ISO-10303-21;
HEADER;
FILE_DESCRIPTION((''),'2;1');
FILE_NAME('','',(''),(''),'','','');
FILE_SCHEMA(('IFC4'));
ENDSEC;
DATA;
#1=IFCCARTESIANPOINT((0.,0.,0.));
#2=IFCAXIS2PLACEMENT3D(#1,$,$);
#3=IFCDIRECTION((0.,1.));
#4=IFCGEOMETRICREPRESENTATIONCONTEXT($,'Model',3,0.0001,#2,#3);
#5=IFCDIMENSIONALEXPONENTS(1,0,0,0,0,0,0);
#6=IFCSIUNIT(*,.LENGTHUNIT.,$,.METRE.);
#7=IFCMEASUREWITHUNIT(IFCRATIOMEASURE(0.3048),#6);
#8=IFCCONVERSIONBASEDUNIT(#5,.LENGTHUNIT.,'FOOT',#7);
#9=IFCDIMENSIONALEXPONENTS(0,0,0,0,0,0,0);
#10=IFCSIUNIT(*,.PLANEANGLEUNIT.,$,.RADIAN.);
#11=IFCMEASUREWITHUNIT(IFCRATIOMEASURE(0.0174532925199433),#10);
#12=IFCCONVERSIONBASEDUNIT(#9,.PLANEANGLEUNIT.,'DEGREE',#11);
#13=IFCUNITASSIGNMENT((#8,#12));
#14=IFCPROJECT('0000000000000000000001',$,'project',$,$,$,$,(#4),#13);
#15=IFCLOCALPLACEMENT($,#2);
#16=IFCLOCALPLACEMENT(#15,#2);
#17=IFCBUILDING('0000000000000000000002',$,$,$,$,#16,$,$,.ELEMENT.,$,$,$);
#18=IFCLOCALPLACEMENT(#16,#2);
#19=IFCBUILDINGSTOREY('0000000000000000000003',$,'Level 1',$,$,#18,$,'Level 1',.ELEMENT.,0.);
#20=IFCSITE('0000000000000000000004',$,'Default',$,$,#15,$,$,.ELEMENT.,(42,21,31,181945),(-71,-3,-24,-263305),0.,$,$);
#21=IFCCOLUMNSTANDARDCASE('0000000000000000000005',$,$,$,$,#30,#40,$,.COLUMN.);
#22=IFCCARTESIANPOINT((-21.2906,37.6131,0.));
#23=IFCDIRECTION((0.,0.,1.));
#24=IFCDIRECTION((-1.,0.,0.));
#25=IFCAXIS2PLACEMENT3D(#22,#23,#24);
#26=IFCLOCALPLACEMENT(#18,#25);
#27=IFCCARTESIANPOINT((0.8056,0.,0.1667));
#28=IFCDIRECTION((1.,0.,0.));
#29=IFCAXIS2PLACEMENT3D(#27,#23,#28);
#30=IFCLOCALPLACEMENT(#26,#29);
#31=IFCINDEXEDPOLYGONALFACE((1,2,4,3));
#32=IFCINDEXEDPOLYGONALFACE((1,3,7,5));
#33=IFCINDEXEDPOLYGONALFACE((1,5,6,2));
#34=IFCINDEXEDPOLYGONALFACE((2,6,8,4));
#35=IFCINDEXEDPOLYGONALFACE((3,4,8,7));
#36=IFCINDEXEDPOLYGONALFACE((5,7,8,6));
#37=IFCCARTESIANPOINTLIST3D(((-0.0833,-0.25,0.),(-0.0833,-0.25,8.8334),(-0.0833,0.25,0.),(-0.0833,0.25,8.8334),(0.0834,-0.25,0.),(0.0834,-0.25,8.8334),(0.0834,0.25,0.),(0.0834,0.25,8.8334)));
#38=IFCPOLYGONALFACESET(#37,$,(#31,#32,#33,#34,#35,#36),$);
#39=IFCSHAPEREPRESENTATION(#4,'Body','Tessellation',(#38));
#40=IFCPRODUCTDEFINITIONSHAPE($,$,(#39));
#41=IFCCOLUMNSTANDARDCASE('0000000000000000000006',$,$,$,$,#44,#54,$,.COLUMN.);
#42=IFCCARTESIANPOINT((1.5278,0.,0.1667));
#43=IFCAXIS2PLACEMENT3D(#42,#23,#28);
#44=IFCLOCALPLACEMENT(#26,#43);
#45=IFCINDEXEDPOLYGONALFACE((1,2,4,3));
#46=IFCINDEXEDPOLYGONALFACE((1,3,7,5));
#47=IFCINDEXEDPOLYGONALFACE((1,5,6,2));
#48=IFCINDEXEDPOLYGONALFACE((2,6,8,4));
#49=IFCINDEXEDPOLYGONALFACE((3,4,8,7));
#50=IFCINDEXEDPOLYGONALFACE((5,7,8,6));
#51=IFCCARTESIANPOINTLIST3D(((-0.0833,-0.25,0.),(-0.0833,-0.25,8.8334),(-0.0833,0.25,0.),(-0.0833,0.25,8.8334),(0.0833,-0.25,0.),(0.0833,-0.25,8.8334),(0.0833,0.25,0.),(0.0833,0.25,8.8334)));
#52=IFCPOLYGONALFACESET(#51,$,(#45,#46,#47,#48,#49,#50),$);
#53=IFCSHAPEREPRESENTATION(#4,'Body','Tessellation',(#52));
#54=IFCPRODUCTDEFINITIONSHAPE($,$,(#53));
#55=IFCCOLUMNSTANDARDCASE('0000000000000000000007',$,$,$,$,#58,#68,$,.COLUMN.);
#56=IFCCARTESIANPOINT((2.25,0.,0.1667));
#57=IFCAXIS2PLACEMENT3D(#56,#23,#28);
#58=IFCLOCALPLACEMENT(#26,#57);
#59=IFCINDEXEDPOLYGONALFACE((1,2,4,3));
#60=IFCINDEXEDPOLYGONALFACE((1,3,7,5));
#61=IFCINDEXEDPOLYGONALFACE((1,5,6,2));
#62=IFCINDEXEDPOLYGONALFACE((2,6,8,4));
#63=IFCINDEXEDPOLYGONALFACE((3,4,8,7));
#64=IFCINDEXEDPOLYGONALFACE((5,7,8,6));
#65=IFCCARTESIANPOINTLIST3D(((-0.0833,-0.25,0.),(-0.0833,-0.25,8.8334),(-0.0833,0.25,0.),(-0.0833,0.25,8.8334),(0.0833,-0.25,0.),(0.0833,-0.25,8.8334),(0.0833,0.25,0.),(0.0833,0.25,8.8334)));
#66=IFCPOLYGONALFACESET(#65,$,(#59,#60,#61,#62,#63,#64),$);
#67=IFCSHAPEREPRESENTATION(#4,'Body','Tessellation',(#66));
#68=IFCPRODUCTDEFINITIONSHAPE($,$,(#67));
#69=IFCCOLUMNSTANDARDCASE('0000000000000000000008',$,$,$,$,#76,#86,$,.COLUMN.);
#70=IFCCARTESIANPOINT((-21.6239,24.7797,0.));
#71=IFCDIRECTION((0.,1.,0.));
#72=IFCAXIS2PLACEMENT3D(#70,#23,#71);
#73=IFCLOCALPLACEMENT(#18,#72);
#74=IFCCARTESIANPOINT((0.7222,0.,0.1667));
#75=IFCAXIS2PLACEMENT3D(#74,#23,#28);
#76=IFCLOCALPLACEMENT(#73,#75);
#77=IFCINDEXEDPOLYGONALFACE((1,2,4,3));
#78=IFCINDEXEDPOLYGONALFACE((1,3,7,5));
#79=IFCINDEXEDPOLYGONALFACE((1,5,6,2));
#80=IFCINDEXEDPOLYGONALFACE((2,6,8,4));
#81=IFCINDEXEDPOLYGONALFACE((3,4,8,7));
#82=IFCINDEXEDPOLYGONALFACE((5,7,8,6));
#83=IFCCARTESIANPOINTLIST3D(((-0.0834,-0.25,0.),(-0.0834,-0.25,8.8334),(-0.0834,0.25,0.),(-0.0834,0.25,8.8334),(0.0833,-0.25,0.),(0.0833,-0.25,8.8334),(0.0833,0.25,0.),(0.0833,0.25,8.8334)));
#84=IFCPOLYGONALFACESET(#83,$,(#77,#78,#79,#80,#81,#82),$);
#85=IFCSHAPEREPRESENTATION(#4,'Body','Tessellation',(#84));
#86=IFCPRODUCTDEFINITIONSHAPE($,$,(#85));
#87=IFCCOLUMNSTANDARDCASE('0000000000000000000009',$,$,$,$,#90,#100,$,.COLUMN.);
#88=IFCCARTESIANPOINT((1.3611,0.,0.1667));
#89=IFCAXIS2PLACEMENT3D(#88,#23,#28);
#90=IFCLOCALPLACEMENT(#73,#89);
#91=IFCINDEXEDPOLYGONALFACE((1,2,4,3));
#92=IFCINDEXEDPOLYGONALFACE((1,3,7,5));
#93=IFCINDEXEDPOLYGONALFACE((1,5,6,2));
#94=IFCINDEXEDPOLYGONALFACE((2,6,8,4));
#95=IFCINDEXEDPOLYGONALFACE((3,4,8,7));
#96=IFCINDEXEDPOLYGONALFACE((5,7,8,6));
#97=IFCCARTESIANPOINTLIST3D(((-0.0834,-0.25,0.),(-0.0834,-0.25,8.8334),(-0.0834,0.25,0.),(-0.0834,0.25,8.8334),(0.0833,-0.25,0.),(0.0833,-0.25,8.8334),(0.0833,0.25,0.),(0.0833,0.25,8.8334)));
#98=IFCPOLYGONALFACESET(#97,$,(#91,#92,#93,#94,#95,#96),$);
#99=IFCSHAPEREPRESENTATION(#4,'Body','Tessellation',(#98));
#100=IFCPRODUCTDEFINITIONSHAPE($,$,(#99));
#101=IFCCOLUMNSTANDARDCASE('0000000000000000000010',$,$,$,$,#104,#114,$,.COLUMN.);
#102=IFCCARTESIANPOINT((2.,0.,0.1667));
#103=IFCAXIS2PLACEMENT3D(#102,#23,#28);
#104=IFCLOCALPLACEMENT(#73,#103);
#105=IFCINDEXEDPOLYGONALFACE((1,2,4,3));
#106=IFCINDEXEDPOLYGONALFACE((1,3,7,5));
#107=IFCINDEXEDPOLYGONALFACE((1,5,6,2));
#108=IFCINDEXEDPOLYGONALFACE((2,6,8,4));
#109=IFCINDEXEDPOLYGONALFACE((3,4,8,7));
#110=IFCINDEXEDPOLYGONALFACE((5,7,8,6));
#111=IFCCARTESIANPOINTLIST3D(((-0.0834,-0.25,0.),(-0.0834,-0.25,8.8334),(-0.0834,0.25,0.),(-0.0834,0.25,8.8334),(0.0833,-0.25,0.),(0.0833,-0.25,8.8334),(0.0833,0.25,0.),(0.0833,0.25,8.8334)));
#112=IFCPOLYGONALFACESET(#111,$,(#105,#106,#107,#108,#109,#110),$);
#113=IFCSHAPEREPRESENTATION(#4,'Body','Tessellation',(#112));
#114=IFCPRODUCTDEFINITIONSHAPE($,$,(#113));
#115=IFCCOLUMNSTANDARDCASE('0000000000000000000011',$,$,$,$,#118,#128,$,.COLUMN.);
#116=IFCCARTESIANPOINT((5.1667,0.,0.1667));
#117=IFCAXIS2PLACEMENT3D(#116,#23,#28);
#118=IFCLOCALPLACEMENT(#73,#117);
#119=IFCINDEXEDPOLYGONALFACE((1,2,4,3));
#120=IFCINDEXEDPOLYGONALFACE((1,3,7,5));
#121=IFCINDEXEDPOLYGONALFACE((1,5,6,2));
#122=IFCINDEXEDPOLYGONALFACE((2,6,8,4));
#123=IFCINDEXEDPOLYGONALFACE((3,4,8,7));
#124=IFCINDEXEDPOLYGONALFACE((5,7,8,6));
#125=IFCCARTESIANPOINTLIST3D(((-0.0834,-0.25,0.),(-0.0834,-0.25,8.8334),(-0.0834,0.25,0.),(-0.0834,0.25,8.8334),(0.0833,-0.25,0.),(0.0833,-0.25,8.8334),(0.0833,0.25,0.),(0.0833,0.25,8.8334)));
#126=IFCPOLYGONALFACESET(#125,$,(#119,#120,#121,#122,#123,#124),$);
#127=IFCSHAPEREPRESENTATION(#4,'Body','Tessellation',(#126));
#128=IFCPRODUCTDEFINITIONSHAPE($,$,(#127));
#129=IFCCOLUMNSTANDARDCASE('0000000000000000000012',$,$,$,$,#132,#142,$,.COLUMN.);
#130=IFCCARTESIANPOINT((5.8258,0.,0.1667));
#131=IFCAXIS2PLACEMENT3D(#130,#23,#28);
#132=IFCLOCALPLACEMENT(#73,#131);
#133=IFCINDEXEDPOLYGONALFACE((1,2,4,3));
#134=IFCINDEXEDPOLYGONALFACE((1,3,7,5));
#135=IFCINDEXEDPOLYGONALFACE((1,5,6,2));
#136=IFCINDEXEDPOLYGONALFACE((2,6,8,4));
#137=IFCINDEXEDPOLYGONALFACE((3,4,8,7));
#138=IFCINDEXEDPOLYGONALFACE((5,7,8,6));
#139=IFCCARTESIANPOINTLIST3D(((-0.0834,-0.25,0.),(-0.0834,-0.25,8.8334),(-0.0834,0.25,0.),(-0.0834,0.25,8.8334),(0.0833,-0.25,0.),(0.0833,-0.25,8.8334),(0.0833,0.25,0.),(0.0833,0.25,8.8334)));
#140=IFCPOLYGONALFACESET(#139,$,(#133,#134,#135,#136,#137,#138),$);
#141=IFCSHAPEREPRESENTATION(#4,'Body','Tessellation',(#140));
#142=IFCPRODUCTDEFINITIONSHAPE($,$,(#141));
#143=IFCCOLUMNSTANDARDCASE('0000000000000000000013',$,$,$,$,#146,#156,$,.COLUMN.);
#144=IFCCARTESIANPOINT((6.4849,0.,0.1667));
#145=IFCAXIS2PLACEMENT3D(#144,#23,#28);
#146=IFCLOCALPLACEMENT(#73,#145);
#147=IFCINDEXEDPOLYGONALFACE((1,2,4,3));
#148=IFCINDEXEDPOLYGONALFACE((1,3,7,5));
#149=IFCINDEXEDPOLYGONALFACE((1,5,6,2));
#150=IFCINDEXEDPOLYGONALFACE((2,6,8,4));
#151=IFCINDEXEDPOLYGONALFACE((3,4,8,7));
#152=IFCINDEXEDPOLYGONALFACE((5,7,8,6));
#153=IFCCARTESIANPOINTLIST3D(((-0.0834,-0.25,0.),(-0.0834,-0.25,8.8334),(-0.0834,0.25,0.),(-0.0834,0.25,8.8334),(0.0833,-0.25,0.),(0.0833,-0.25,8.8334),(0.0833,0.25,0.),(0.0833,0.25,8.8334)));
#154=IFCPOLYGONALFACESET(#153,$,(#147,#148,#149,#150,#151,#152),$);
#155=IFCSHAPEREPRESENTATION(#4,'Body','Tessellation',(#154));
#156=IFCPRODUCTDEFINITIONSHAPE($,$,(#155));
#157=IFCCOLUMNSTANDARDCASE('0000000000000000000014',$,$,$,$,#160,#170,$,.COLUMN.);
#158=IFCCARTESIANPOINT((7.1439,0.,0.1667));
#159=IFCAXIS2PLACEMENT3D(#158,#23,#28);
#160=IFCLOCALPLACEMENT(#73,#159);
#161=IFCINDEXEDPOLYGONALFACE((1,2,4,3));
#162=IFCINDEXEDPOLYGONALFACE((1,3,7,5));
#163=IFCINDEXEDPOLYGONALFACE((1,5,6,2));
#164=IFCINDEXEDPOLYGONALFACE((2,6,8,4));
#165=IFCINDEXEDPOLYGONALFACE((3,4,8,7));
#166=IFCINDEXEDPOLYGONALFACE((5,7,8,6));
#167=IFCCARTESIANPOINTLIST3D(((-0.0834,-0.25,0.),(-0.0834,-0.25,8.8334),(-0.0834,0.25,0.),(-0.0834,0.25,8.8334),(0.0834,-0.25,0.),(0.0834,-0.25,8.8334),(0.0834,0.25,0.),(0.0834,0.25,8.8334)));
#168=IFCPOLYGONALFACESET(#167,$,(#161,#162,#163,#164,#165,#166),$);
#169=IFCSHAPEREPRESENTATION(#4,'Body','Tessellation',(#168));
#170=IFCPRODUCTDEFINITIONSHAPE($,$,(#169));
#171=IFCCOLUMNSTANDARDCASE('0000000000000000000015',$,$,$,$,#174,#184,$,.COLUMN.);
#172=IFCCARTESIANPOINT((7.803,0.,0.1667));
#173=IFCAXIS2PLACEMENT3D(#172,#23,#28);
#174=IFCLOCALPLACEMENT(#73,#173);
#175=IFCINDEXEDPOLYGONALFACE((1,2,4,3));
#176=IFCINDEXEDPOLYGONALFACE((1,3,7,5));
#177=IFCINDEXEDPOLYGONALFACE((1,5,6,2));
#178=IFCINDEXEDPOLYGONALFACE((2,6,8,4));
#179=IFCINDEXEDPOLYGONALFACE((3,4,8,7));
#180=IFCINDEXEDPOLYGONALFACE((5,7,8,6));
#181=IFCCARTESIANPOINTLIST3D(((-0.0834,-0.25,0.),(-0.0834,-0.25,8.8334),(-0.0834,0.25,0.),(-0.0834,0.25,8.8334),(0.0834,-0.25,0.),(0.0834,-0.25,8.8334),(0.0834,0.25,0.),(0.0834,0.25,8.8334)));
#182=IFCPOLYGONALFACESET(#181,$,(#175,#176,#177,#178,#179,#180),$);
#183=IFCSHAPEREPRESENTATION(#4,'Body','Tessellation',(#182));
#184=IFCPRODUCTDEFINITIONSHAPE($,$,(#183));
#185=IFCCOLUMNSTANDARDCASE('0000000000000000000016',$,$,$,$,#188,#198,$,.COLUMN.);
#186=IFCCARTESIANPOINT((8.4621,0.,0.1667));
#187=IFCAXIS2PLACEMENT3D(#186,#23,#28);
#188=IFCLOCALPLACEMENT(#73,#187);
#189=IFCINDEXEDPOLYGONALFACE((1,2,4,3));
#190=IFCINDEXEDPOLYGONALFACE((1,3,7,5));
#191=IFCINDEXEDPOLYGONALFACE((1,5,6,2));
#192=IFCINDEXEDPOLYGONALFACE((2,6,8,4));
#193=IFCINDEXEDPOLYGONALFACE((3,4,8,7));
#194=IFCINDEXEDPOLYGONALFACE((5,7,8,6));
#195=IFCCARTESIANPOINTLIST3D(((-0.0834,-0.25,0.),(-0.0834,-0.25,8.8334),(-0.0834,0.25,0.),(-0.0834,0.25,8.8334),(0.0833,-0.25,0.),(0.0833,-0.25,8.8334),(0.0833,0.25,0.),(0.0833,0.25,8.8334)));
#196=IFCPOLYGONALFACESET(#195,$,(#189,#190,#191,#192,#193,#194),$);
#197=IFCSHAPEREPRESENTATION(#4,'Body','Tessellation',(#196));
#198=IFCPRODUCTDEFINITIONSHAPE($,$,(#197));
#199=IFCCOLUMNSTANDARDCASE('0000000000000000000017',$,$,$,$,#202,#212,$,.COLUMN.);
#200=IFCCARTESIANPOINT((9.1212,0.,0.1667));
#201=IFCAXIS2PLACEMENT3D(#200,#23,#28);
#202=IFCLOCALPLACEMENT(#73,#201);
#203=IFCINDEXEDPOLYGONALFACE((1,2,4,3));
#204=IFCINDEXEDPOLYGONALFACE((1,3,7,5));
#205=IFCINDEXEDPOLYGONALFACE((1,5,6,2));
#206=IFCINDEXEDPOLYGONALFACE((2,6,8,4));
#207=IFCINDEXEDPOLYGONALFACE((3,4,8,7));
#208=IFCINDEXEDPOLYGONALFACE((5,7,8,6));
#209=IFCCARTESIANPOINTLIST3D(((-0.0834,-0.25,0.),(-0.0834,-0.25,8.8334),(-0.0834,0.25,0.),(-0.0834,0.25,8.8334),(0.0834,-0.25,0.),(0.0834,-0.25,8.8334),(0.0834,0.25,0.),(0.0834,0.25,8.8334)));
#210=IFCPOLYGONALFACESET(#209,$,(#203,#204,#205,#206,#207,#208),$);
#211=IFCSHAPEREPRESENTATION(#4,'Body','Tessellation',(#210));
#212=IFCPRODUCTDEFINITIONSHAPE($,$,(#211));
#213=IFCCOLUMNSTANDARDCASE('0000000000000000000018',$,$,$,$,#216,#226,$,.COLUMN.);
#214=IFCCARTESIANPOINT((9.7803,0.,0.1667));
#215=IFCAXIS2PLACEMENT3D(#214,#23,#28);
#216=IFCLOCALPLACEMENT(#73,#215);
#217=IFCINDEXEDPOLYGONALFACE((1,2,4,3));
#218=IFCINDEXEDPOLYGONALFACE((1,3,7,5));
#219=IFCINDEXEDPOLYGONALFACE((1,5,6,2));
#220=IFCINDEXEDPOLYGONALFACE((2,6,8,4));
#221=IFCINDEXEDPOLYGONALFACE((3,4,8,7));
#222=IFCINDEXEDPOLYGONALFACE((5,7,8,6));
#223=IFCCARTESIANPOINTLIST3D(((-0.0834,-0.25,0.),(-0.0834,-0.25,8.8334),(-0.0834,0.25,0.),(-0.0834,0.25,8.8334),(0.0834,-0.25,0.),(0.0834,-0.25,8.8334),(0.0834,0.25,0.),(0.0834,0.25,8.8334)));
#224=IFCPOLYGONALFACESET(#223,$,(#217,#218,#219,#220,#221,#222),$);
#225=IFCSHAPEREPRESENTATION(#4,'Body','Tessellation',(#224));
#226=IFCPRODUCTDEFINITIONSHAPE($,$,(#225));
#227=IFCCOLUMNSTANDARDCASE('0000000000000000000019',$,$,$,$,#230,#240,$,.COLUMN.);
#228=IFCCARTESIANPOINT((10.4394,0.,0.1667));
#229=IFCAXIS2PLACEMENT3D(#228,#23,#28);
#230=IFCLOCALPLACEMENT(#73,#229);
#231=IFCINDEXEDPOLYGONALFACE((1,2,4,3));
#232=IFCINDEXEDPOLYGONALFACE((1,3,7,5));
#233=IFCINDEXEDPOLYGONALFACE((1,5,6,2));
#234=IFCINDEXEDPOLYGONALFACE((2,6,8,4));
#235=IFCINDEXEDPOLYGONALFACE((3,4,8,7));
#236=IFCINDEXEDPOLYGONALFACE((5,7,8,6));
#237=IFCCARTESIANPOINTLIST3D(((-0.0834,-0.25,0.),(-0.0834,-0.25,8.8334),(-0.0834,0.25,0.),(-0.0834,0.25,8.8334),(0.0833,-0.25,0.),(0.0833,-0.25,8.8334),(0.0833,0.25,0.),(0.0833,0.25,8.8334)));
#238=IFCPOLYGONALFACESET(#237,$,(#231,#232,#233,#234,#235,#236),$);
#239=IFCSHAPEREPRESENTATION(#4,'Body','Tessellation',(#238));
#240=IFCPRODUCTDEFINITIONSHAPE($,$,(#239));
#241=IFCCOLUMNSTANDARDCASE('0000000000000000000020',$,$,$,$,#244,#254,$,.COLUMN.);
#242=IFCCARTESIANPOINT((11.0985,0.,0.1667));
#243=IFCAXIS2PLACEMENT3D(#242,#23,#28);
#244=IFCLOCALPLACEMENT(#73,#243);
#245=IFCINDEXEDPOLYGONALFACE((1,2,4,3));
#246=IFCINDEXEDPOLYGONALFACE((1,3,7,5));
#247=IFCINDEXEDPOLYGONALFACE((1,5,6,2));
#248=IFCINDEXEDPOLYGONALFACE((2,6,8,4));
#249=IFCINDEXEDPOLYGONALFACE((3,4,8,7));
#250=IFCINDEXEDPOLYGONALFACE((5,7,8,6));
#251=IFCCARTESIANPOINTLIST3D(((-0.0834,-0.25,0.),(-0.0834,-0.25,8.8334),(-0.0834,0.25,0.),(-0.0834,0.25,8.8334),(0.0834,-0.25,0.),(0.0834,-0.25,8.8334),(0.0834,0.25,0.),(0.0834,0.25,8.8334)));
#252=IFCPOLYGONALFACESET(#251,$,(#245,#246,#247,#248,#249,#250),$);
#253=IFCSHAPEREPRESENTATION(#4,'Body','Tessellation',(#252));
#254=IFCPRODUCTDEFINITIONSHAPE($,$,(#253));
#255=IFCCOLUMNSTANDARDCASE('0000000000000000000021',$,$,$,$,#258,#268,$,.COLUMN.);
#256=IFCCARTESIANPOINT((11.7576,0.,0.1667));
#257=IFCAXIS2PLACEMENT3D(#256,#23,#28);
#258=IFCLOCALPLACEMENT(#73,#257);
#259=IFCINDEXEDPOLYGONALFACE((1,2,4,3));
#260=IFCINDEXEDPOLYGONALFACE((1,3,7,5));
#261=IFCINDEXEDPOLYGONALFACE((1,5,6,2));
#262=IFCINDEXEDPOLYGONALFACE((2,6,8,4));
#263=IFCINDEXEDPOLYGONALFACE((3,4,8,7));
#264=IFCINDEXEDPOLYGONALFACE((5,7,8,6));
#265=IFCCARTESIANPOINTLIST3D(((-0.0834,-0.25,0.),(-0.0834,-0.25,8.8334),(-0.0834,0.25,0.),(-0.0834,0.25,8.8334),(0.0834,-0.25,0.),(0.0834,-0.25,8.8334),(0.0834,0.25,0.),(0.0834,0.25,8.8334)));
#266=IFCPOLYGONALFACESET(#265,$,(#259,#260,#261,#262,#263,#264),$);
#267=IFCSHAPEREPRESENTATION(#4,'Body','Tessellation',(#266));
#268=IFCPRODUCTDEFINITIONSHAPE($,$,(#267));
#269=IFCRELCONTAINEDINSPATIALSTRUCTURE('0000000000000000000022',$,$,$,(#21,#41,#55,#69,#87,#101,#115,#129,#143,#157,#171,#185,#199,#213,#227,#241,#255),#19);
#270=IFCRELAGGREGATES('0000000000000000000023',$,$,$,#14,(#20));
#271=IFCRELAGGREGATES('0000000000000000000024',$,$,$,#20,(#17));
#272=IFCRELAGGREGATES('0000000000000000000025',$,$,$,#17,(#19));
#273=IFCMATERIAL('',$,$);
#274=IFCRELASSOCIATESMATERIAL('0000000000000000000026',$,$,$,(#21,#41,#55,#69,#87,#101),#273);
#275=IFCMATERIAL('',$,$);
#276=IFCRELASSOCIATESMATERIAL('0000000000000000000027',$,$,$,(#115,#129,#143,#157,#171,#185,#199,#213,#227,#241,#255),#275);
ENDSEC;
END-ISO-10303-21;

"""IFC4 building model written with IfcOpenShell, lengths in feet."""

from ifc_helpers import new_model, entity, si_unit, converted_unit, direction, frame, origin, place, context, project, spatial, rectangle, extrude, material, element, save


model = new_model("IFC4")

# Units and contexts
model_context = context("Model", 3, precision=0.0001, world=origin(), true_north=direction((0.0, 1.0)))
ifc_project = project(units=[converted_unit("LENGTHUNIT", "FOOT", entity("IfcRatioMeasure", 0.3048), si_unit("LENGTHUNIT", "METRE"), dimensions=[1, 0, 0, 0, 0, 0, 0]), converted_unit("PLANEANGLEUNIT", "DEGREE", entity("IfcRatioMeasure", 0.0174532925199433), si_unit("PLANEANGLEUNIT", "RADIAN"), dimensions=[0, 0, 0, 0, 0, 0, 0])], contexts=[model_context])

# Site, building, storey
site_placement = place(None, origin())
site = spatial("IfcSite", under=ifc_project, at=site_placement, Name="Default", CompositionType="ELEMENT", RefLatitude=(42, 21, 31, 181945), RefLongitude=(-71, -3, -24, -263305), RefElevation=0.0)
building_placement = place(site_placement, origin())
building = spatial("IfcBuilding", under=site, at=building_placement, CompositionType="ELEMENT")
storey_placement = place(building_placement, origin())
storey = spatial("IfcBuildingStorey", under=building, at=storey_placement, Name="Level 1", LongName="Level 1", CompositionType="ELEMENT", Elevation=0.0)

# Columns
ifc_material_1 = material(Name="")
placement_1 = place(storey_placement, frame((-21.2906, 37.6131, 0.0), z_axis=(0.0, 0.0, 1.0), x_axis=(-1.0, 0.0, 0.0)))
for number, where, z_axis, x_axis in (
    (1, (0.8056, 0.0, 0.1667), (0.0, 0.0, 1.0), (1.0, 0.0, 0.0)),
    (2, (1.5278, 0.0, 0.1667), (0.0, 0.0, 1.0), (1.0, 0.0, 0.0)),
    (3, (2.25, 0.0, 0.1667), (0.0, 0.0, 1.0), (1.0, 0.0, 0.0)),
):
    element("IfcColumnStandardCase", number, at=place(placement_1, frame(where, z_axis=z_axis, x_axis=x_axis)), inside=storey, material=ifc_material_1, PredefinedType="COLUMN", context=model_context, shape_type="SweptSolid", body=[
        extrude(rectangle(XDim=0.1667, YDim=0.5), origin(), (0.0, 0.0, 1.0), 8.8334),
    ])
placement_2 = place(storey_placement, frame((-21.6239, 24.7797, 0.0), z_axis=(0.0, 0.0, 1.0), x_axis=(0.0, 1.0, 0.0)))
for number, where, z_axis, x_axis in (
    (4, (0.7222, 0.0, 0.1667), (0.0, 0.0, 1.0), (1.0, 0.0, 0.0)),
    (5, (1.3611, 0.0, 0.1667), (0.0, 0.0, 1.0), (1.0, 0.0, 0.0)),
    (6, (2.0, 0.0, 0.1667), (0.0, 0.0, 1.0), (1.0, 0.0, 0.0)),
):
    element("IfcColumnStandardCase", number, at=place(placement_2, frame(where, z_axis=z_axis, x_axis=x_axis)), inside=storey, material=ifc_material_1, PredefinedType="COLUMN", context=model_context, shape_type="SweptSolid", body=[
        extrude(rectangle(XDim=0.1667, YDim=0.5), origin(), (0.0, 0.0, 1.0), 8.8334),
    ])
ifc_material_2 = material(Name="")
for number, where, z_axis, x_axis in (
    (7, (5.1667, 0.0, 0.1667), (0.0, 0.0, 1.0), (1.0, 0.0, 0.0)),
    (8, (5.8258, 0.0, 0.1667), (0.0, 0.0, 1.0), (1.0, 0.0, 0.0)),
    (9, (6.4849, 0.0, 0.1667), (0.0, 0.0, 1.0), (1.0, 0.0, 0.0)),
    (10, (7.1439, 0.0, 0.1667), (0.0, 0.0, 1.0), (1.0, 0.0, 0.0)),
    (11, (7.803, 0.0, 0.1667), (0.0, 0.0, 1.0), (1.0, 0.0, 0.0)),
    (12, (8.4621, 0.0, 0.1667), (0.0, 0.0, 1.0), (1.0, 0.0, 0.0)),
    (13, (9.1212, 0.0, 0.1667), (0.0, 0.0, 1.0), (1.0, 0.0, 0.0)),
    (14, (9.7803, 0.0, 0.1667), (0.0, 0.0, 1.0), (1.0, 0.0, 0.0)),
    (15, (10.4394, 0.0, 0.1667), (0.0, 0.0, 1.0), (1.0, 0.0, 0.0)),
    (16, (11.0985, 0.0, 0.1667), (0.0, 0.0, 1.0), (1.0, 0.0, 0.0)),
    (17, (11.7576, 0.0, 0.1667), (0.0, 0.0, 1.0), (1.0, 0.0, 0.0)),
):
    element("IfcColumnStandardCase", number, at=place(placement_2, frame(where, z_axis=z_axis, x_axis=x_axis)), inside=storey, material=ifc_material_2, PredefinedType="COLUMN", context=model_context, shape_type="SweptSolid", body=[
        extrude(rectangle(XDim=0.1667, YDim=0.5), origin(), (0.0, 0.0, 1.0), 8.8334),
    ])

save(model, "model.ifc")
